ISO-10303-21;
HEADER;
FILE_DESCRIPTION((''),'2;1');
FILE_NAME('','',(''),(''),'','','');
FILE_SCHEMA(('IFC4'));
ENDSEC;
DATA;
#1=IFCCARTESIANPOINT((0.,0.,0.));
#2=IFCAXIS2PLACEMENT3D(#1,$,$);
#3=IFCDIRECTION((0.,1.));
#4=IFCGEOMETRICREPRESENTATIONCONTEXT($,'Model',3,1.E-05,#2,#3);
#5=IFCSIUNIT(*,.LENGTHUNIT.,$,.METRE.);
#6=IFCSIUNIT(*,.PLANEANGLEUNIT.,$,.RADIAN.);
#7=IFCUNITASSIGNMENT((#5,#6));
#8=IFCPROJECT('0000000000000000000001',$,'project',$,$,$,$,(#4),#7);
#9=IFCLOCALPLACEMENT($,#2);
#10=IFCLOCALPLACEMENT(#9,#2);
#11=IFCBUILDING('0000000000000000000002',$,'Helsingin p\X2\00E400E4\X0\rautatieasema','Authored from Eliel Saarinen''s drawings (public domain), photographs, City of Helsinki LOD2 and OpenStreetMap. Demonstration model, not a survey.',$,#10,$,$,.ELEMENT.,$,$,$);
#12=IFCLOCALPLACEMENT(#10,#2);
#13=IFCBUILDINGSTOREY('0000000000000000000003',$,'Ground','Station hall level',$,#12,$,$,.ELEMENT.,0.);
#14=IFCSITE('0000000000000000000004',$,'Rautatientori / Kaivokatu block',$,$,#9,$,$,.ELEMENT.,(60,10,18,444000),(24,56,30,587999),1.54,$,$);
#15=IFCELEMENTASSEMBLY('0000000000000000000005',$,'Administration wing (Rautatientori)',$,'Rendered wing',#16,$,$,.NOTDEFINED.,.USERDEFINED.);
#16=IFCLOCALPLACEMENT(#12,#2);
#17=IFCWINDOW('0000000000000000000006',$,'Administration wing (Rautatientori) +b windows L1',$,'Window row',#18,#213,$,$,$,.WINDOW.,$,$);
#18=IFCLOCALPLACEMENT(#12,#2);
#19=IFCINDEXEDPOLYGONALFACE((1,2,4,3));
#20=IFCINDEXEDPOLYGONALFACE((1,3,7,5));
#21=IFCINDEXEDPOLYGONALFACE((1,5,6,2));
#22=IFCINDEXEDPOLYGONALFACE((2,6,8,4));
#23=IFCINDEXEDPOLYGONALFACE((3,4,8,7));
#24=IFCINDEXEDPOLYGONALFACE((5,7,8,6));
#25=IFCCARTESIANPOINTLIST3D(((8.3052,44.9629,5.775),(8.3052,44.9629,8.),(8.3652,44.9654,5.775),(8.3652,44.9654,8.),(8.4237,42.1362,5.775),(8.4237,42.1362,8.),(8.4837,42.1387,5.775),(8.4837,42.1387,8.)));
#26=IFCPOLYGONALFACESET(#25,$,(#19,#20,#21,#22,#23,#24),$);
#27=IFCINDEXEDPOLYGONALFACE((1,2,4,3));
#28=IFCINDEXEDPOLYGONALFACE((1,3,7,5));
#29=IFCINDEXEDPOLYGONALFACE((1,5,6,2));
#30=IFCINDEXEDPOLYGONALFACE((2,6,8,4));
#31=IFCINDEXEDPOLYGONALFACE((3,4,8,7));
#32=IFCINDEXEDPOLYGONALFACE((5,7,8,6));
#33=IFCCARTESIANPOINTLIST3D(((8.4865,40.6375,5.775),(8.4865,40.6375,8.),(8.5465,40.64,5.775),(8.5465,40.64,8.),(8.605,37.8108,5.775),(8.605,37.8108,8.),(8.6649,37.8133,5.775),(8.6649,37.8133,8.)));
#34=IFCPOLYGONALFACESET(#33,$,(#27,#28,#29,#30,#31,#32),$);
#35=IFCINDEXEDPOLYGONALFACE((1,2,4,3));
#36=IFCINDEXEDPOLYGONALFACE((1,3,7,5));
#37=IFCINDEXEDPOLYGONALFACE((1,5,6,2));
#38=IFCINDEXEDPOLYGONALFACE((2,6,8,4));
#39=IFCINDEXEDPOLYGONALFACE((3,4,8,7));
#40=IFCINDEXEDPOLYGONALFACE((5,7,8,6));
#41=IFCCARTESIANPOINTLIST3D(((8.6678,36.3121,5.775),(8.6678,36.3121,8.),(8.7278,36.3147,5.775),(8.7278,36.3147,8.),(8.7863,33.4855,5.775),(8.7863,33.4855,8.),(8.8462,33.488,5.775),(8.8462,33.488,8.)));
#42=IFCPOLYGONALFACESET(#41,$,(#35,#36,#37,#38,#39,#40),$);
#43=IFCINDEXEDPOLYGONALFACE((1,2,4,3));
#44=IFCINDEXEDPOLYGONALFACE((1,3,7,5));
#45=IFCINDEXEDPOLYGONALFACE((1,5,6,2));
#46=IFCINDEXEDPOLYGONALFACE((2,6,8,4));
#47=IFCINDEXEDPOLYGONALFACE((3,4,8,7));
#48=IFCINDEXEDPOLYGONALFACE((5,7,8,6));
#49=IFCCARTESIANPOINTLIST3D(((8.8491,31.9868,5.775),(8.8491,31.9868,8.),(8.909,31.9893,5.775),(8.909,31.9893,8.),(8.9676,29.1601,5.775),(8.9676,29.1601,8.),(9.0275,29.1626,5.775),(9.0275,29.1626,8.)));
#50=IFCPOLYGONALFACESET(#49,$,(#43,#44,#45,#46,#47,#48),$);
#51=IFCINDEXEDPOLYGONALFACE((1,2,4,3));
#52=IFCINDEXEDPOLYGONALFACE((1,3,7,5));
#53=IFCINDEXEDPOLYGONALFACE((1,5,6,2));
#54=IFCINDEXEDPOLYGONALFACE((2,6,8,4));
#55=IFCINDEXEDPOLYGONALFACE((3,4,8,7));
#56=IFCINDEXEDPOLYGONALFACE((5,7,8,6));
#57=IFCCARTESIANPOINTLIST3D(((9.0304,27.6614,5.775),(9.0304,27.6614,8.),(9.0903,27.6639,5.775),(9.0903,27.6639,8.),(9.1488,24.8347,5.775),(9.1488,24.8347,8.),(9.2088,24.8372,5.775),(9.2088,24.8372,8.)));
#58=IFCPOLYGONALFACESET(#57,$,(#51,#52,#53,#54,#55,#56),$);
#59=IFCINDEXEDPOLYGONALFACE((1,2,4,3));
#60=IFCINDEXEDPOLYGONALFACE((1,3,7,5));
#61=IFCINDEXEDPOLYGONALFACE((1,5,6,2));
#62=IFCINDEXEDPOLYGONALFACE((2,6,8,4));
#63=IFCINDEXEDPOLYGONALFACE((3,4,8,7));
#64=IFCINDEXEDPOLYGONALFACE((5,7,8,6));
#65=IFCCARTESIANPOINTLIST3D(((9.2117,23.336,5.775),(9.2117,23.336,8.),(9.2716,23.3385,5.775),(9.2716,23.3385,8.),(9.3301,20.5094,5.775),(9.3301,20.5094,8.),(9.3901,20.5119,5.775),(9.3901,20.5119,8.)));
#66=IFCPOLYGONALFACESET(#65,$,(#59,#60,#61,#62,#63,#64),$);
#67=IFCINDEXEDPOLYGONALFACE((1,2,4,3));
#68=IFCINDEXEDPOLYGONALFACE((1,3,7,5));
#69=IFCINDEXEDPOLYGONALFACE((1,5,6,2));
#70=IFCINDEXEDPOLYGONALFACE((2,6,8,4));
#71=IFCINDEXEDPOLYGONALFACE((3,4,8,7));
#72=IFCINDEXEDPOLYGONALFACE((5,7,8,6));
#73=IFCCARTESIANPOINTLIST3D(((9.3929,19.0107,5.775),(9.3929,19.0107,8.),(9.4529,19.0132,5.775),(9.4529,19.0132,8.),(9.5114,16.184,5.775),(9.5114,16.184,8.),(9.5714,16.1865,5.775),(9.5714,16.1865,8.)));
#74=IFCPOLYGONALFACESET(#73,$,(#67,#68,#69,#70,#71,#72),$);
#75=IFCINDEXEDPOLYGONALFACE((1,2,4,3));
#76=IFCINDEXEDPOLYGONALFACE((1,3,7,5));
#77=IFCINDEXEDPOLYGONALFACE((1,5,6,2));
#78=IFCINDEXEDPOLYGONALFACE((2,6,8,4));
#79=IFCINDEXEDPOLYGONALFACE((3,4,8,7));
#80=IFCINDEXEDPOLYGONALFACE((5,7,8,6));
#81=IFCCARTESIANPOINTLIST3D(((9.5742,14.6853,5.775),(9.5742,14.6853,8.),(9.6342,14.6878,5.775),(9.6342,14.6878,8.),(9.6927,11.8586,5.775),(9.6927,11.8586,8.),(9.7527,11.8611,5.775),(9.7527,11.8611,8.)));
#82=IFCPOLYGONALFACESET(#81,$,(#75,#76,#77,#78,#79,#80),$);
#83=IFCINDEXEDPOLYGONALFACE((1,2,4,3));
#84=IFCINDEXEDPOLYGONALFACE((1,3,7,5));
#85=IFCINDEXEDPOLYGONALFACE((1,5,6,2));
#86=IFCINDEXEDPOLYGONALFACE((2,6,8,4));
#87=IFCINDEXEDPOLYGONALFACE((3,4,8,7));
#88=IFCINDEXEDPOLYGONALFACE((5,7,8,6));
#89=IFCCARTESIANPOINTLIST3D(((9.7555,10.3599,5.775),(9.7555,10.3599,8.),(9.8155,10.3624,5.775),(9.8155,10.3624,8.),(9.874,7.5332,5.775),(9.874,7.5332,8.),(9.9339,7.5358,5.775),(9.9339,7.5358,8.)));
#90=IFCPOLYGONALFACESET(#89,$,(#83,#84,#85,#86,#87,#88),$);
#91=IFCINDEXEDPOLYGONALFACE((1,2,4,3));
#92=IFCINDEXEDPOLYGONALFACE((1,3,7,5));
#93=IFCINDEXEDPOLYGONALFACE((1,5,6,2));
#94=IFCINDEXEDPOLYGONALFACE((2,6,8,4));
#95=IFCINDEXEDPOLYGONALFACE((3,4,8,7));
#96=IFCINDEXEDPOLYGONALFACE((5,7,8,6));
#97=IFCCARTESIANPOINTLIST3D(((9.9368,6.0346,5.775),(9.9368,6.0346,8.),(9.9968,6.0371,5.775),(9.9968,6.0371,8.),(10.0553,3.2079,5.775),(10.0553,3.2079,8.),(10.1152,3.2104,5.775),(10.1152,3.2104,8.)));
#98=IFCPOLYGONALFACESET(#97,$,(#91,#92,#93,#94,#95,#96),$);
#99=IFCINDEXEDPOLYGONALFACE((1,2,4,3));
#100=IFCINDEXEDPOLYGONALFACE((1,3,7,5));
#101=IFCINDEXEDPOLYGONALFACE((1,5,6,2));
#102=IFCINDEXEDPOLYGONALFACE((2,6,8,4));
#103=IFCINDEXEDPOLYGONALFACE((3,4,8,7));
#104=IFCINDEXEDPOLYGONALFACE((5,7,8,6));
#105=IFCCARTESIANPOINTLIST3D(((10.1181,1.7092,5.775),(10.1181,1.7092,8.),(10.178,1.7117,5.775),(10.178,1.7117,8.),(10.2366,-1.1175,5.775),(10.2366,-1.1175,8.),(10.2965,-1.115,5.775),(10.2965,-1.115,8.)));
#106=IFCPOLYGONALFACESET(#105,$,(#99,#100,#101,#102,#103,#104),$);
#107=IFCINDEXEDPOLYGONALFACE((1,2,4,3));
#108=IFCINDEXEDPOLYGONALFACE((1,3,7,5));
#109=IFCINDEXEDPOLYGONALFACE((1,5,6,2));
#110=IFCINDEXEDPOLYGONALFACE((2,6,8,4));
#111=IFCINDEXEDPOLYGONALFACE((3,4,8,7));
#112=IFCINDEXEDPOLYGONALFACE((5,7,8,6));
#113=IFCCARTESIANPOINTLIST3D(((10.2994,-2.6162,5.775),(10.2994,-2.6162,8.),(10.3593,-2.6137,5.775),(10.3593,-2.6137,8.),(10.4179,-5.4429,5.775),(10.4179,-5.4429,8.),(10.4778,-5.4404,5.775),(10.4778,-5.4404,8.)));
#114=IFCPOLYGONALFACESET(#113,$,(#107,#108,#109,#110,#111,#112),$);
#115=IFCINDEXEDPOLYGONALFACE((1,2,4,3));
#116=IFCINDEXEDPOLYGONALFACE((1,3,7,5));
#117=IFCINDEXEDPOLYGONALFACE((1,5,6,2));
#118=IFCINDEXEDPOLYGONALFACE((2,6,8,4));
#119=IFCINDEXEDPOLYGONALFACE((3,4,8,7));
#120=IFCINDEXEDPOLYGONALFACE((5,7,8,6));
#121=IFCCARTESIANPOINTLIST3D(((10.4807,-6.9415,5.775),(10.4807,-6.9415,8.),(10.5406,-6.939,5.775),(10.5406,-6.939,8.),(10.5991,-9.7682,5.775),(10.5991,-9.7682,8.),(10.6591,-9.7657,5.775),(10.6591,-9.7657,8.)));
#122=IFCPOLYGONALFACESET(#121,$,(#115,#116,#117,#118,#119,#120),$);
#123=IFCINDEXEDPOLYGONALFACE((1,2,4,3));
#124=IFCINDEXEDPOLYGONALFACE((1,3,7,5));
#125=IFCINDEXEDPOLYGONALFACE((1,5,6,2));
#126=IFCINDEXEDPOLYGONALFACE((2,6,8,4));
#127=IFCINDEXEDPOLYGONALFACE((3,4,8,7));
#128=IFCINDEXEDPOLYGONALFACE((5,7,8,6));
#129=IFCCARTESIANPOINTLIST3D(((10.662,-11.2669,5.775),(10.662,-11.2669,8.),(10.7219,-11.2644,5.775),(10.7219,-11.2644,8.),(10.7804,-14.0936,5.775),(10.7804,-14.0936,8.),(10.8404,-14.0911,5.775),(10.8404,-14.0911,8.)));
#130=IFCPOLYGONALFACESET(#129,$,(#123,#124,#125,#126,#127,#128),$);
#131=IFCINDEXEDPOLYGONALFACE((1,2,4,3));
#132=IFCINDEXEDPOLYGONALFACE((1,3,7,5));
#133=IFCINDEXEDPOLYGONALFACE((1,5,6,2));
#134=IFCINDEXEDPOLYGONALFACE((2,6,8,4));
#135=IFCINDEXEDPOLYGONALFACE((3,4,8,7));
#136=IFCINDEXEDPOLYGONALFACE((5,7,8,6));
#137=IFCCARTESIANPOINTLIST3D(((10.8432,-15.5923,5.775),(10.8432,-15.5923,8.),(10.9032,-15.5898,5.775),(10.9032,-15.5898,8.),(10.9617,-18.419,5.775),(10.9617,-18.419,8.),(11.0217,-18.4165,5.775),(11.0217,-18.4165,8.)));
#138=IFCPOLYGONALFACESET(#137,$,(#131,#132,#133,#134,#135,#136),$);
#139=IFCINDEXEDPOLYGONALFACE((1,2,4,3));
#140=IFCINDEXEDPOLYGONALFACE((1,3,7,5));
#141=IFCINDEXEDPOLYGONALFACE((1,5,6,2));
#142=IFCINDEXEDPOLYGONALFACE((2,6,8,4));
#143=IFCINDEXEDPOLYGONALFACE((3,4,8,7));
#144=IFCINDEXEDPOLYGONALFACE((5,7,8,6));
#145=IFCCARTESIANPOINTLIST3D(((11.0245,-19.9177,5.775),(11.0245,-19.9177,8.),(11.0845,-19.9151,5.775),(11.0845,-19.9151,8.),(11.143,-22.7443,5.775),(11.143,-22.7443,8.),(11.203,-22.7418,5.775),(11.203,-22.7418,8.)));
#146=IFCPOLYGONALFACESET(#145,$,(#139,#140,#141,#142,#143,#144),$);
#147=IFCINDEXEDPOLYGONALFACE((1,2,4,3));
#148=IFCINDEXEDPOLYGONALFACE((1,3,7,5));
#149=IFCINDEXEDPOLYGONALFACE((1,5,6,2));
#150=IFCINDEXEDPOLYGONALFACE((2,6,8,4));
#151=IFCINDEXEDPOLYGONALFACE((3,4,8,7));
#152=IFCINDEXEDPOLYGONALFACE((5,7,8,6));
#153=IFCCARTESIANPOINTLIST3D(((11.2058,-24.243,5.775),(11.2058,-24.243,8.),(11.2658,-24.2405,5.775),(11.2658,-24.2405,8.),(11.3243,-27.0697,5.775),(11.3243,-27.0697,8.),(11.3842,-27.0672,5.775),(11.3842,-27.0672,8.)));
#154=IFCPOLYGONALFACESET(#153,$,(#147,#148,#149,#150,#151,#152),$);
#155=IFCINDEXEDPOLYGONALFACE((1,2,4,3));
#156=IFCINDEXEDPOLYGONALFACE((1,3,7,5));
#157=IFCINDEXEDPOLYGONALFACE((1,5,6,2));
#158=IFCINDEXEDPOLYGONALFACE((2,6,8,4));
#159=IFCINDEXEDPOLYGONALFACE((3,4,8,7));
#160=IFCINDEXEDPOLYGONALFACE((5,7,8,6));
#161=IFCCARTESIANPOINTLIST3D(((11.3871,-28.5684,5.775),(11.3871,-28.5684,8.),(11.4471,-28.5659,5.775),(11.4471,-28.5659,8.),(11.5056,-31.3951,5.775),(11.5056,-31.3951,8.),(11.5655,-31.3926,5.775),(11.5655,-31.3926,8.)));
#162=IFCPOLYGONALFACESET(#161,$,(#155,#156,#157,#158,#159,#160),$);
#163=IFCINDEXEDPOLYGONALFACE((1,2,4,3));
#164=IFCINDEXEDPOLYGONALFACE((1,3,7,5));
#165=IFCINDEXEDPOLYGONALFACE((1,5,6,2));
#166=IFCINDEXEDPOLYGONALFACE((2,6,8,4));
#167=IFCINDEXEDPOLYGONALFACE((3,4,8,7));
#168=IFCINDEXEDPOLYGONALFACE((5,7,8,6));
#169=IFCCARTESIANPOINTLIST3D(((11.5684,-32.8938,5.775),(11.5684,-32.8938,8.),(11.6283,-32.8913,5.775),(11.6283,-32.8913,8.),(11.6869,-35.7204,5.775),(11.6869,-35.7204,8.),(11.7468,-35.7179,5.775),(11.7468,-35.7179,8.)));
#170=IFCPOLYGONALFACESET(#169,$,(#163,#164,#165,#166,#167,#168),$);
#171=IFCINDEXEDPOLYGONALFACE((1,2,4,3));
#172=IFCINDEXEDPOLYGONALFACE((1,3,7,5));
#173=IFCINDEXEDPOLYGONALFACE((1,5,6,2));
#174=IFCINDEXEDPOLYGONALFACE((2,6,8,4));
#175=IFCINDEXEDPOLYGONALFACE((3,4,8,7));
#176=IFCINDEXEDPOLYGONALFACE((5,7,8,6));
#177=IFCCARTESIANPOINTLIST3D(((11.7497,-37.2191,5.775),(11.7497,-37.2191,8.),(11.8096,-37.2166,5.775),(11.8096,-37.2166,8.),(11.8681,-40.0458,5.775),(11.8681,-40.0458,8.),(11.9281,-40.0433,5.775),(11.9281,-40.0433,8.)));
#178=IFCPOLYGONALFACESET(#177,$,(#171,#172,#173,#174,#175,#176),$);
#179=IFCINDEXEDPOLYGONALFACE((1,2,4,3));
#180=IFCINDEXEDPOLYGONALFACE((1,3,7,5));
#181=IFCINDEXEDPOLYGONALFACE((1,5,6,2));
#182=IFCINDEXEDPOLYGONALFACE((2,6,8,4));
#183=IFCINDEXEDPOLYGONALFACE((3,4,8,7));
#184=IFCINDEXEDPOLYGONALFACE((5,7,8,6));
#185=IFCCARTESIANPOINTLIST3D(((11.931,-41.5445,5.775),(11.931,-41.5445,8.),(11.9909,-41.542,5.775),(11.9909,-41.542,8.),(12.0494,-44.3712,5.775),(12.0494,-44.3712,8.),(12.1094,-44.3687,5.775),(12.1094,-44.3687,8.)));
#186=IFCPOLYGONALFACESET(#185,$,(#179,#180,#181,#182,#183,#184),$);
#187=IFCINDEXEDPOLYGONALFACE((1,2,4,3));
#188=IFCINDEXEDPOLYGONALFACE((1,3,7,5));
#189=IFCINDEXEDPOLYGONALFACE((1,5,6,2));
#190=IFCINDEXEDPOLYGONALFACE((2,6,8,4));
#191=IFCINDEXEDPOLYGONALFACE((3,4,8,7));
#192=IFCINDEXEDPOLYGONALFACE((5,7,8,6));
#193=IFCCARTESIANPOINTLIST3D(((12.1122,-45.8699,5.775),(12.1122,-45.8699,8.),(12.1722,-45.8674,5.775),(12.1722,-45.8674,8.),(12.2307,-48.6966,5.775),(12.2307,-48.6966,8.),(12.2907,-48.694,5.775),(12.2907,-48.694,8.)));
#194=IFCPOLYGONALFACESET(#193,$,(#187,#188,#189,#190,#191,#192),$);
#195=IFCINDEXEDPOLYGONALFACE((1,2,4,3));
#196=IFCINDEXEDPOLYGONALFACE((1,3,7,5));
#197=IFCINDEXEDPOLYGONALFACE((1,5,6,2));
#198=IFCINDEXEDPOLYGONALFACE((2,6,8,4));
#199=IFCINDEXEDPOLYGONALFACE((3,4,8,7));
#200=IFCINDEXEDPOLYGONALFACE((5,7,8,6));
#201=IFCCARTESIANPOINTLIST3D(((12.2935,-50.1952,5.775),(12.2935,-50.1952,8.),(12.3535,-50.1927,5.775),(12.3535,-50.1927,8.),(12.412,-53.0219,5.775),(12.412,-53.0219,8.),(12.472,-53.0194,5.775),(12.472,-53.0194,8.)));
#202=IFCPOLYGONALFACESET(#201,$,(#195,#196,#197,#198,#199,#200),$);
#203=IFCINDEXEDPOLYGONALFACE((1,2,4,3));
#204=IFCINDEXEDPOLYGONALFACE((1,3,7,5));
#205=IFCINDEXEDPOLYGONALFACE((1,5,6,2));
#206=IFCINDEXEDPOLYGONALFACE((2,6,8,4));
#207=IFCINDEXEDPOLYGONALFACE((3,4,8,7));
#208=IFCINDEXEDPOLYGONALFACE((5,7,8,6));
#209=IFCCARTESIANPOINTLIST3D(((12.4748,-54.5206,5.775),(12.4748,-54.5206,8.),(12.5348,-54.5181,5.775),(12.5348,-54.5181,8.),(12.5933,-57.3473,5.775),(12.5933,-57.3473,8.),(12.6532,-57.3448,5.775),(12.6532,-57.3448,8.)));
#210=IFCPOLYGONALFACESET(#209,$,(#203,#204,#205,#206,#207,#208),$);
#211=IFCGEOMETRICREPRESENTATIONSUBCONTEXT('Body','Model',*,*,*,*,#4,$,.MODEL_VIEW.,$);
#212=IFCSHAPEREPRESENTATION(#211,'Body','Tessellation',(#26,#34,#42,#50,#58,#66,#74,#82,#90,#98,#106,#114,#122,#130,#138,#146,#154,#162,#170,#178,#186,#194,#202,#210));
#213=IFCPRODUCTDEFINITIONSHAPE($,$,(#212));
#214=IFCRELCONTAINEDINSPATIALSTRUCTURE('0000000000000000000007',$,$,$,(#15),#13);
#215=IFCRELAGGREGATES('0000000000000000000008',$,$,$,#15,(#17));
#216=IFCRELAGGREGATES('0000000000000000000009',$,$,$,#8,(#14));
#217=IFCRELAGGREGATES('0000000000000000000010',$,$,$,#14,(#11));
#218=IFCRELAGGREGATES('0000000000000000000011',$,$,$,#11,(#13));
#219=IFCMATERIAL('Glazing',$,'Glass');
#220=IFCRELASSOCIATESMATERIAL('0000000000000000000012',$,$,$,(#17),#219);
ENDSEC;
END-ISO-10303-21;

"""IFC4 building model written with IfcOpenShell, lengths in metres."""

from ifc_helpers import new_model, si_unit, direction, frame, frame_2d, origin, place, context, subcontext, project, spatial, rectangle, extrude, material, element, aggregate, save


model = new_model("IFC4")

# Units and contexts
model_context = context("Model", 3, precision=1e-05, world=origin(), true_north=direction((0.0, 1.0)))
body_context = subcontext(model_context, "Body", "Model", "MODEL_VIEW")
ifc_project = project(units=[si_unit("LENGTHUNIT", "METRE"), si_unit("PLANEANGLEUNIT", "RADIAN")], contexts=[model_context])

# Site, building, storey
site_placement = place(None, origin())
site = spatial("IfcSite", under=ifc_project, at=site_placement, Name="Rautatientori / Kaivokatu block", CompositionType="ELEMENT", RefLatitude=(60, 10, 18, 444000), RefLongitude=(24, 56, 30, 587999), RefElevation=1.54)
building_placement = place(site_placement, origin())
building = spatial("IfcBuilding", under=site, at=building_placement, Name="Helsingin päärautatieasema", Description="Authored from Eliel Saarinen's drawings (public domain), photographs, City of Helsinki LOD2 and OpenStreetMap. Demonstration model, not a survey.", CompositionType="ELEMENT")
storey_placement = place(building_placement, origin())
storey = spatial("IfcBuildingStorey", under=building, at=storey_placement, Name="Ground", Description="Station hall level", CompositionType="ELEMENT", Elevation=0.0)

# Element assembly, window
assembly_placement = place(building_placement, origin())
assembly = element("IfcElementAssembly", 1, at=assembly_placement, inside=storey, Name="Administration wing (Rautatientori)", ObjectType="Rendered wing", AssemblyPlace="NOTDEFINED", PredefinedType="USERDEFINED")
ifc_material_1 = material(Name="Glazing", Category="Glass")
window_1_placement = place(building_placement, origin())
window_1 = element("IfcWindow", 2, at=window_1_placement, material=ifc_material_1, Name="Administration wing (Rautatientori) +b windows L1", ObjectType="Window row", PredefinedType="WINDOW", context=body_context, shape_type="SweptSolid", body=[
    extrude(rectangle(XDim=2.8292, YDim=0.06, at=frame_2d((0.0, 0.0), x_axis=(0.041876, -0.999123))), frame((8.3944, 43.5508, 5.775)), (0.0, 0.0, 1.0), 2.225),
    extrude(rectangle(XDim=2.8292, YDim=0.06, at=frame_2d((0.0, 0.0), x_axis=(0.041876, -0.999123))), frame((8.5757, 39.2254, 5.775)), (0.0, 0.0, 1.0), 2.225),
    extrude(rectangle(XDim=2.8292, YDim=0.06, at=frame_2d((0.0, 0.0), x_axis=(0.041876, -0.999123))), frame((8.757, 34.9001, 5.775)), (0.0, 0.0, 1.0), 2.225),
    extrude(rectangle(XDim=2.8292, YDim=0.06, at=frame_2d((0.0, 0.0), x_axis=(0.041876, -0.999123))), frame((8.9383, 30.5747, 5.775)), (0.0, 0.0, 1.0), 2.225),
    extrude(rectangle(XDim=2.8292, YDim=0.06, at=frame_2d((0.0, 0.0), x_axis=(0.041876, -0.999123))), frame((9.1196, 26.2493, 5.775)), (0.0, 0.0, 1.0), 2.225),
    extrude(rectangle(XDim=2.8292, YDim=0.06, at=frame_2d((0.0, 0.0), x_axis=(0.041876, -0.999123))), frame((9.3009, 21.9239, 5.775)), (0.0, 0.0, 1.0), 2.225),
    extrude(rectangle(XDim=2.8292, YDim=0.06, at=frame_2d((0.0, 0.0), x_axis=(0.041876, -0.999123))), frame((9.4822, 17.5986, 5.775)), (0.0, 0.0, 1.0), 2.225),
    extrude(rectangle(XDim=2.8292, YDim=0.06, at=frame_2d((0.0, 0.0), x_axis=(0.041876, -0.999123))), frame((9.6634, 13.2732, 5.775)), (0.0, 0.0, 1.0), 2.225),
    extrude(rectangle(XDim=2.8292, YDim=0.06, at=frame_2d((0.0, 0.0), x_axis=(0.041876, -0.999123))), frame((9.8447, 8.9478, 5.775)), (0.0, 0.0, 1.0), 2.225),
    extrude(rectangle(XDim=2.8292, YDim=0.06, at=frame_2d((0.0, 0.0), x_axis=(0.041876, -0.999123))), frame((10.026, 4.6225, 5.775)), (0.0, 0.0, 1.0), 2.225),
    extrude(rectangle(XDim=2.8292, YDim=0.06, at=frame_2d((0.0, 0.0), x_axis=(0.041876, -0.999123))), frame((10.2073, 0.2971, 5.775)), (0.0, 0.0, 1.0), 2.225),
    extrude(rectangle(XDim=2.8292, YDim=0.06, at=frame_2d((0.0, 0.0), x_axis=(0.041876, -0.999123))), frame((10.3886, -4.0283, 5.775)), (0.0, 0.0, 1.0), 2.225),
    extrude(rectangle(XDim=2.8292, YDim=0.06, at=frame_2d((0.0, 0.0), x_axis=(0.041876, -0.999123))), frame((10.5699, -8.3536, 5.775)), (0.0, 0.0, 1.0), 2.225),
    extrude(rectangle(XDim=2.8292, YDim=0.06, at=frame_2d((0.0, 0.0), x_axis=(0.041876, -0.999123))), frame((10.7512, -12.679, 5.775)), (0.0, 0.0, 1.0), 2.225),
    extrude(rectangle(XDim=2.8292, YDim=0.06, at=frame_2d((0.0, 0.0), x_axis=(0.041876, -0.999123))), frame((10.9325, -17.0044, 5.775)), (0.0, 0.0, 1.0), 2.225),
    extrude(rectangle(XDim=2.8292, YDim=0.06, at=frame_2d((0.0, 0.0), x_axis=(0.041876, -0.999123))), frame((11.1137, -21.3297, 5.775)), (0.0, 0.0, 1.0), 2.225),
    extrude(rectangle(XDim=2.8292, YDim=0.06, at=frame_2d((0.0, 0.0), x_axis=(0.041876, -0.999123))), frame((11.295, -25.6551, 5.775)), (0.0, 0.0, 1.0), 2.225),
    extrude(rectangle(XDim=2.8292, YDim=0.06, at=frame_2d((0.0, 0.0), x_axis=(0.041876, -0.999123))), frame((11.4763, -29.9805, 5.775)), (0.0, 0.0, 1.0), 2.225),
    extrude(rectangle(XDim=2.8292, YDim=0.06, at=frame_2d((0.0, 0.0), x_axis=(0.041876, -0.999123))), frame((11.6576, -34.3059, 5.775)), (0.0, 0.0, 1.0), 2.225),
    extrude(rectangle(XDim=2.8292, YDim=0.06, at=frame_2d((0.0, 0.0), x_axis=(0.041876, -0.999123))), frame((11.8389, -38.6312, 5.775)), (0.0, 0.0, 1.0), 2.225),
    extrude(rectangle(XDim=2.8292, YDim=0.06, at=frame_2d((0.0, 0.0), x_axis=(0.041876, -0.999123))), frame((12.0202, -42.9566, 5.775)), (0.0, 0.0, 1.0), 2.225),
    extrude(rectangle(XDim=2.8292, YDim=0.06, at=frame_2d((0.0, 0.0), x_axis=(0.041876, -0.999123))), frame((12.2015, -47.282, 5.775)), (0.0, 0.0, 1.0), 2.225),
    extrude(rectangle(XDim=2.8292, YDim=0.06, at=frame_2d((0.0, 0.0), x_axis=(0.041876, -0.999123))), frame((12.3827, -51.6073, 5.775)), (0.0, 0.0, 1.0), 2.225),
    extrude(rectangle(XDim=2.8292, YDim=0.06, at=frame_2d((0.0, 0.0), x_axis=(0.041876, -0.999123))), frame((12.564, -55.9327, 5.775)), (0.0, 0.0, 1.0), 2.225),
])
aggregate(assembly, [window_1])

save(model, "model.ifc")
